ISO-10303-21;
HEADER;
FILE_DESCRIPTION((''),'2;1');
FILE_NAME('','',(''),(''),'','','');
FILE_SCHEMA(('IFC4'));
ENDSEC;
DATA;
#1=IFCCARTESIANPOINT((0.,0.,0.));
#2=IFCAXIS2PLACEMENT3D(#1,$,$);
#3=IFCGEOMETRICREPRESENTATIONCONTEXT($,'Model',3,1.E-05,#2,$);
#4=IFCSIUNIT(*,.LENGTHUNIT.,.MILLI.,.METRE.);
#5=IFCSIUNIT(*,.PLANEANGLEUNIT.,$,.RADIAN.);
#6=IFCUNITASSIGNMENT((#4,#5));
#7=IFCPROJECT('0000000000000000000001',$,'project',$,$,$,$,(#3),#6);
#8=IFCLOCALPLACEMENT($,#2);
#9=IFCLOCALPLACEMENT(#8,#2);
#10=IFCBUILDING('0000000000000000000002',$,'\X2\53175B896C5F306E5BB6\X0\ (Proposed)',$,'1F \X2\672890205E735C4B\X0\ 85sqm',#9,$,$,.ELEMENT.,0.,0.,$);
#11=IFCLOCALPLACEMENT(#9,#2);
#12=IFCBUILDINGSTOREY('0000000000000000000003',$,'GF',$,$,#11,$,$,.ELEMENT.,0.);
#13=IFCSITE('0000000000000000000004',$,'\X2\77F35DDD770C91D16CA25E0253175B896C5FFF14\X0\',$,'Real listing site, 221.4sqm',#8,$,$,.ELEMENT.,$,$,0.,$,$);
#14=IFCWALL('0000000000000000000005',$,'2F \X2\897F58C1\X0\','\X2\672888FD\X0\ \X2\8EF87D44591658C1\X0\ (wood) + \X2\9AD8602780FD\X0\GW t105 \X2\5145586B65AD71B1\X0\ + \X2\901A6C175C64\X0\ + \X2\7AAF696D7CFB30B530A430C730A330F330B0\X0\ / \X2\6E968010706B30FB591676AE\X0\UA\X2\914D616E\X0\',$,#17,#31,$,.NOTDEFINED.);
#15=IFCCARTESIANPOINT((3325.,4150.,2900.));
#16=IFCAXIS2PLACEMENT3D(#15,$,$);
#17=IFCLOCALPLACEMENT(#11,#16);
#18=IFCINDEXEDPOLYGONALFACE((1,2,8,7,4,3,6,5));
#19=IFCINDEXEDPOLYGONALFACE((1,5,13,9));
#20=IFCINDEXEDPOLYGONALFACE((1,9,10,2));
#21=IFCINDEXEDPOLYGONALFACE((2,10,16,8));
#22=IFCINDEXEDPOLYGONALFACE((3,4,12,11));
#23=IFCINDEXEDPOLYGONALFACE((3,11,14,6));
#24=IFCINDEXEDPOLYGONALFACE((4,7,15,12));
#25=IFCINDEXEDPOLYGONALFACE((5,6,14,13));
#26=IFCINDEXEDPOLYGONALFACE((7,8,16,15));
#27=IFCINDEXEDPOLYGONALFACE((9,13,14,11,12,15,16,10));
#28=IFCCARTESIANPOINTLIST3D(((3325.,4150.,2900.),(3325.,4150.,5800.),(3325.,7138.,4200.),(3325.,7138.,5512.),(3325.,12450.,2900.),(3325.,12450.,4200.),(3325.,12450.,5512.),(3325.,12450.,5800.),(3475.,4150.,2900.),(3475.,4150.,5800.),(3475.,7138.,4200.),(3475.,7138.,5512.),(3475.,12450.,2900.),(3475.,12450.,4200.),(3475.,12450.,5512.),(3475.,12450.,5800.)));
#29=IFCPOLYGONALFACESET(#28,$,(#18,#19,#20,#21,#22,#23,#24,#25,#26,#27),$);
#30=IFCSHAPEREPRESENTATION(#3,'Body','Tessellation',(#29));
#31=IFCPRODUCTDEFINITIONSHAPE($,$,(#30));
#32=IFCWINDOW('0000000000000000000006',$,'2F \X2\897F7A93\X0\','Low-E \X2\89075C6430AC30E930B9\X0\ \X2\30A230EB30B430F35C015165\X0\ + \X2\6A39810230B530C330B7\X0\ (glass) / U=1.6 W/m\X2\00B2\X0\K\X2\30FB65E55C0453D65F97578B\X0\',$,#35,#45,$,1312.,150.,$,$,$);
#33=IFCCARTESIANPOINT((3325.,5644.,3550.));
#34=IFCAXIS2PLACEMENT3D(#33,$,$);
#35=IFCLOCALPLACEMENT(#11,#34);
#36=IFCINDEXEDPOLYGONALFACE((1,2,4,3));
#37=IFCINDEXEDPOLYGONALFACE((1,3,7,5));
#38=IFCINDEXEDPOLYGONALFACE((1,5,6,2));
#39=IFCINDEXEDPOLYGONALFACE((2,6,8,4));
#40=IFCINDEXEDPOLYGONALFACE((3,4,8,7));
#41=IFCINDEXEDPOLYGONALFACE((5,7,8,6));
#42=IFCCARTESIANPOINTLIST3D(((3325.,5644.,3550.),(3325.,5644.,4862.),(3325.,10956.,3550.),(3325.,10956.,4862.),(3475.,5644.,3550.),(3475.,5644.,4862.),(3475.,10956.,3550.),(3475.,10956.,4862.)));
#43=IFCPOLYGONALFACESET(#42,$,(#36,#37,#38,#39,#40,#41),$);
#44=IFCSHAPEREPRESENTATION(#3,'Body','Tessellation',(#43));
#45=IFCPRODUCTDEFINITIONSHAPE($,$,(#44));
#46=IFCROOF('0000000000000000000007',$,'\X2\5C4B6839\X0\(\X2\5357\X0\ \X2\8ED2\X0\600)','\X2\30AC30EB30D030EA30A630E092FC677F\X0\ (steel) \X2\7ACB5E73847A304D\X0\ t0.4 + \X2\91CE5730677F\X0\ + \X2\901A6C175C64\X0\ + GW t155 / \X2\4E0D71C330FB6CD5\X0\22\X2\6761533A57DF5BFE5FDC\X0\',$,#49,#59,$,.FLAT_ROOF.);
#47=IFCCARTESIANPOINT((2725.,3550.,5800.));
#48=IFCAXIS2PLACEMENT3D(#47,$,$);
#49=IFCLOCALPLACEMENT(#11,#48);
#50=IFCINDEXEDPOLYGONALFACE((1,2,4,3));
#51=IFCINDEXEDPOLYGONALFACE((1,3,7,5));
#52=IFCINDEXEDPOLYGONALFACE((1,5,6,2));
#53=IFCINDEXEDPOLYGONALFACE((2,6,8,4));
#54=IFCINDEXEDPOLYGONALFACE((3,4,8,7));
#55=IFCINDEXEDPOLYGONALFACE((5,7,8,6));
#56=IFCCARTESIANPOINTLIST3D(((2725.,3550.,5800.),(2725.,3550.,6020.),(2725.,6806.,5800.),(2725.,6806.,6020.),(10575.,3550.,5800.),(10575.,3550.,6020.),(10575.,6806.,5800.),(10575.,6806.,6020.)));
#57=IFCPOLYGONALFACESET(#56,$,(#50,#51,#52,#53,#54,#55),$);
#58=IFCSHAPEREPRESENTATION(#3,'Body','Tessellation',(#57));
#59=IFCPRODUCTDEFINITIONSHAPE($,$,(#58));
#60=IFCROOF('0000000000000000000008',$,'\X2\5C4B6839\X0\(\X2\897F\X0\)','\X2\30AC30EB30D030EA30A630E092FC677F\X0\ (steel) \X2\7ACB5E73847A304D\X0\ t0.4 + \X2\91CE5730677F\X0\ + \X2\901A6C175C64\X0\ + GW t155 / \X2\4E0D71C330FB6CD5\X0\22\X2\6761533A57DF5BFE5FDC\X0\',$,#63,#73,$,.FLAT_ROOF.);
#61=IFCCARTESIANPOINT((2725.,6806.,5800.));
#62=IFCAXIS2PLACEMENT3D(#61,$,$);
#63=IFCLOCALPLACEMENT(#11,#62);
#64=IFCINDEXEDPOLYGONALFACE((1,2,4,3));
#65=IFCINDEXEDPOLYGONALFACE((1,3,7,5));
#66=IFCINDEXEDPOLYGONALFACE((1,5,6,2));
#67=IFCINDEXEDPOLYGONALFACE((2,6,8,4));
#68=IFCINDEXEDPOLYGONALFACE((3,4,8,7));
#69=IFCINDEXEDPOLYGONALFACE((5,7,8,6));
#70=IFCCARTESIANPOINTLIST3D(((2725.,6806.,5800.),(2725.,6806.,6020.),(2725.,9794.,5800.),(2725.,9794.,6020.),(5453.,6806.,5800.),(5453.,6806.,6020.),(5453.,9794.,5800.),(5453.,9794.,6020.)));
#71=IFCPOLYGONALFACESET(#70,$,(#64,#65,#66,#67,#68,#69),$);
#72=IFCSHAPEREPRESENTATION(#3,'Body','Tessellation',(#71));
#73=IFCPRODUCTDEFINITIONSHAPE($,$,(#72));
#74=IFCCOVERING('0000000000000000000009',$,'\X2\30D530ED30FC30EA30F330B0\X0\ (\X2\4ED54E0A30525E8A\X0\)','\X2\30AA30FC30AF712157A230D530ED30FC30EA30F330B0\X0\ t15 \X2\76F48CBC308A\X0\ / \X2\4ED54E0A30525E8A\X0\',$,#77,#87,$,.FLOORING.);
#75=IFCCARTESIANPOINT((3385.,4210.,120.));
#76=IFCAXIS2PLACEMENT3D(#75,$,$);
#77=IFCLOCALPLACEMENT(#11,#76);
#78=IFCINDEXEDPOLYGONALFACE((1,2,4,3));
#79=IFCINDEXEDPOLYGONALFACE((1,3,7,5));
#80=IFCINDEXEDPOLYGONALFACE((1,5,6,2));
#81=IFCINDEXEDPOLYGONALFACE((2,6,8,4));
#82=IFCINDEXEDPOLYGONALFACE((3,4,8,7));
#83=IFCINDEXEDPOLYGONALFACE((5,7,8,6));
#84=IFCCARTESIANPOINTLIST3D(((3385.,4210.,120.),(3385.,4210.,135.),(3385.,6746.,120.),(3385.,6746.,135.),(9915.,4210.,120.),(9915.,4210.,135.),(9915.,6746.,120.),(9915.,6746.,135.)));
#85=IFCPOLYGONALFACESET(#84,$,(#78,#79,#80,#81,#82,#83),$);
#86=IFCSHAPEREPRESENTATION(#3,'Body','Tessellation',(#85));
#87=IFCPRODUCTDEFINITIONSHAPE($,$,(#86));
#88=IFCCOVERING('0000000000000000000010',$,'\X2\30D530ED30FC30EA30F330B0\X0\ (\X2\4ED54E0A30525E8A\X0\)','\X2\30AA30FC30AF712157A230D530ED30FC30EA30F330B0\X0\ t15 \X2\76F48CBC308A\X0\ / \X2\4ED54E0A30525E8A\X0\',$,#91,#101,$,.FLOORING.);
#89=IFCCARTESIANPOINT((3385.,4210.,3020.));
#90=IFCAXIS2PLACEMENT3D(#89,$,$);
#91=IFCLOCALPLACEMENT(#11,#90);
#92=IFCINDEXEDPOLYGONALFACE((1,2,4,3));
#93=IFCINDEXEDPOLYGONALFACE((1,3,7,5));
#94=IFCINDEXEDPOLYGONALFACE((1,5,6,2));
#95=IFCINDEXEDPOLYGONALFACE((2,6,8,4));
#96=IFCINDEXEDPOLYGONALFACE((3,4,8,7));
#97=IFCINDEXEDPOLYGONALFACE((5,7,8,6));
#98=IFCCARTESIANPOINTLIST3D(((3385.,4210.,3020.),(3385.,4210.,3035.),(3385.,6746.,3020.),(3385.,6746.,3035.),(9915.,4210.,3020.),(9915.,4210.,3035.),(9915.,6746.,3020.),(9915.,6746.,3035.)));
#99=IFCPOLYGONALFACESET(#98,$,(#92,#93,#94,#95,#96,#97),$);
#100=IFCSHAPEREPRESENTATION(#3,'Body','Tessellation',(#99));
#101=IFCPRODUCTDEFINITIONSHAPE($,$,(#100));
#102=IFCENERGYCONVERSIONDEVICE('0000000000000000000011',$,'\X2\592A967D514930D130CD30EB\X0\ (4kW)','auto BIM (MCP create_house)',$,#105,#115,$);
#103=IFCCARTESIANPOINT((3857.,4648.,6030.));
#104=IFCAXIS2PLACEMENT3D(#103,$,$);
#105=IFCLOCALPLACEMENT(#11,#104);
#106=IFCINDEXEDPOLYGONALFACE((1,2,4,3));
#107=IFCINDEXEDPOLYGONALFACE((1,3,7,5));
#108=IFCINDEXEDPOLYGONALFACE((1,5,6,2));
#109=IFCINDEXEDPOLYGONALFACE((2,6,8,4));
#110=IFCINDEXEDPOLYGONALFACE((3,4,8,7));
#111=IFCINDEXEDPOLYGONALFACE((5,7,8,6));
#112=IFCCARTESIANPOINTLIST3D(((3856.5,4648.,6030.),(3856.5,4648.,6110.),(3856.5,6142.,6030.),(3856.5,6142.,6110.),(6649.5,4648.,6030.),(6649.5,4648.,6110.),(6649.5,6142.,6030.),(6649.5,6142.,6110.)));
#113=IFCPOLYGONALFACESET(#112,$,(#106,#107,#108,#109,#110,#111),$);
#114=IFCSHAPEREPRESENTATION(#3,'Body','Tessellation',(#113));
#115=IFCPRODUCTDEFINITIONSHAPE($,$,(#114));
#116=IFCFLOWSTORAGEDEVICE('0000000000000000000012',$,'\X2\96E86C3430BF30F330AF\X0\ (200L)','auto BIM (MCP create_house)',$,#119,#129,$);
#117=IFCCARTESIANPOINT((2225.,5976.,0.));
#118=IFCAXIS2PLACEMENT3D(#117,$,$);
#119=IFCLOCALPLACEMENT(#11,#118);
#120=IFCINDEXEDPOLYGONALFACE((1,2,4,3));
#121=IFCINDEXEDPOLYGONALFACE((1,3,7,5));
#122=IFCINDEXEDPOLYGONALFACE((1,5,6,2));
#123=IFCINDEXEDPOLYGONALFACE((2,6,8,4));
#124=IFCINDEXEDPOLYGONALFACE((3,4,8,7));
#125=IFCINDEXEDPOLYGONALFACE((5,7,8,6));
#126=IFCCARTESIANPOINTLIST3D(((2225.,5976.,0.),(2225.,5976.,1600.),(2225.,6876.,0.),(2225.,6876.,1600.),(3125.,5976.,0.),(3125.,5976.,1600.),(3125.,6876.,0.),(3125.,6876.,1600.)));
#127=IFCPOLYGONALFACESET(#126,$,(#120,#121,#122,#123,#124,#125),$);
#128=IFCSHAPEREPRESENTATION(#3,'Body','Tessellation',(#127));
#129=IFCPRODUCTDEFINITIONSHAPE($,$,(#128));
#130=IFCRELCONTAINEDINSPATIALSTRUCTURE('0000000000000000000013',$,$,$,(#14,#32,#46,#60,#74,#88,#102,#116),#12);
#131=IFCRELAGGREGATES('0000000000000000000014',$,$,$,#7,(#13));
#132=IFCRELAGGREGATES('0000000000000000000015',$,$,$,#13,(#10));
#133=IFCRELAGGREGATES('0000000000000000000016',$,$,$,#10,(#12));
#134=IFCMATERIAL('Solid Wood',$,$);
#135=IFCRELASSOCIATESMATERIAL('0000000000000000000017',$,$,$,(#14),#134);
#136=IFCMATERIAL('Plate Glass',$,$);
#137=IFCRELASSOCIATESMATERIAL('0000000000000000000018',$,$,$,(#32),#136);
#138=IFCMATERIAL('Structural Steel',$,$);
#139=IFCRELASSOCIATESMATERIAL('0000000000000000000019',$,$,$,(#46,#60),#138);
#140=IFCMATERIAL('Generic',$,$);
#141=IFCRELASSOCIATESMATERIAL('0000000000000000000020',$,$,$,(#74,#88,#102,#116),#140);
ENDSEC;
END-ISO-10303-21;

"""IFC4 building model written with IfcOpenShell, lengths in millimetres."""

from ifc_helpers import new_model, si_unit, frame, frame_2d, origin, place, context, project, spatial, rectangle, extrude, material, element, fill, save


model = new_model("IFC4")

# Units and contexts
model_context = context("Model", 3, precision=1e-05, world=origin())
ifc_project = project(units=[si_unit("LENGTHUNIT", "METRE", prefix="MILLI"), si_unit("PLANEANGLEUNIT", "RADIAN")], contexts=[model_context])

# Site, building, storey
site_placement = place(None, origin())
site = spatial("IfcSite", under=ifc_project, at=site_placement, Name="石川県金沢市北安江４", ObjectType="Real listing site, 221.4sqm", CompositionType="ELEMENT", RefElevation=0.0)
building_placement = place(site_placement, origin())
building = spatial("IfcBuilding", under=site, at=building_placement, Name="北安江の家 (Proposed)", ObjectType="1F 木造平屋 85sqm", CompositionType="ELEMENT", ElevationOfRefHeight=0.0, ElevationOfTerrain=0.0)
storey_placement = place(building_placement, origin())
storey = spatial("IfcBuildingStorey", under=building, at=storey_placement, Name="GF", CompositionType="ELEMENT", Elevation=0.0)

# Shared definitions
ifc_material_1 = material(Name="Solid Wood")
ifc_material_2 = material(Name="Generic")

# Shared definitions
ifc_material_3 = material(Name="Plate Glass")

# Wall, opening, window
wall_1_placement = place(storey_placement, frame((3325.0, 4150.0, 2900.0)))
wall_1 = element("IfcWall", 1, at=wall_1_placement, inside=storey, material=ifc_material_1, Name="2F 西壁", Description="木製 軸組外壁 (wood) + 高性能GW t105 充填断熱 + 通気層 + 窯業系サイディング / 準耐火・外皮UA配慮", PredefinedType="NOTDEFINED", context=model_context, shape_type="SweptSolid", body=[
    extrude(rectangle(XDim=150.0, YDim=8300.0, at=frame_2d((75.0, 4150.0))), frame((3325.0, 4150.0, 2900.0)), (0.0, 0.0, 1.0), 2900.0),
])
opening_1_placement = place(storey_placement, frame((3325.0, 5644.0, 3550.0)))
opening_1 = element("IfcOpeningElement", 2, at=opening_1_placement, cuts=wall_1, PredefinedType="NOTDEFINED", context=model_context, shape_type="SweptSolid", body=[
    extrude(rectangle(XDim=150.0, YDim=5312.0, at=frame_2d((75.0, 2656.0))), frame((3325.0, 5644.0, 3550.0)), (0.0, 0.0, 1.0), 1312.0),
])
window_1_placement = place(storey_placement, frame((3325.0, 5644.0, 3550.0)))
window_1 = element("IfcWindow", 3, at=window_1_placement, inside=storey, material=ifc_material_3, Name="2F 西窓", Description="Low-E 複層ガラス アルゴン封入 + 樹脂サッシ (glass) / U=1.6 W/m²K・日射取得型", OverallHeight=1312.0, OverallWidth=150.0, context=model_context, shape_type="SweptSolid", body=[
    extrude(rectangle(XDim=150.0, YDim=5312.0, at=frame_2d((75.0, 2656.0))), frame((3325.0, 5644.0, 3550.0)), (0.0, 0.0, 1.0), 1312.0),
])
fill(opening_1, window_1)

# Roofs
ifc_material_4 = material(Name="Structural Steel")
roof_1_placement = place(storey_placement, frame((2725.0, 3550.0, 5800.0)))
element("IfcRoof", 4, at=roof_1_placement, inside=storey, material=ifc_material_4, Name="屋根(南 軒600)", Description="ガルバリウム鋼板 (steel) 立平葺き t0.4 + 野地板 + 通気層 + GW t155 / 不燃・法22条区域対応", PredefinedType="FLAT_ROOF", context=model_context, shape_type="SweptSolid", body=[
    extrude(rectangle(XDim=7850.0, YDim=3256.0, at=frame_2d((3925.0, 1628.0))), frame((2725.0, 3550.0, 5800.0)), (0.0, 0.0, 1.0), 220.0),
])
roof_2_placement = place(storey_placement, frame((2725.0, 6806.0, 5800.0)))
element("IfcRoof", 5, at=roof_2_placement, inside=storey, material=ifc_material_4, Name="屋根(西)", Description="ガルバリウム鋼板 (steel) 立平葺き t0.4 + 野地板 + 通気層 + GW t155 / 不燃・法22条区域対応", PredefinedType="FLAT_ROOF", context=model_context, shape_type="SweptSolid", body=[
    extrude(rectangle(XDim=2728.0, YDim=2988.0, at=frame_2d((1364.0, 1494.0))), frame((2725.0, 6806.0, 5800.0)), (0.0, 0.0, 1.0), 220.0),
])

# Coverings
covering_1_placement = place(storey_placement, frame((3385.0, 4210.0, 120.0)))
element("IfcCovering", 6, at=covering_1_placement, inside=storey, material=ifc_material_2, Name="フローリング (仕上げ床)", Description="オーク無垢フローリング t15 直貼り / 仕上げ床", PredefinedType="FLOORING", context=model_context, shape_type="SweptSolid", body=[
    extrude(rectangle(XDim=6530.0, YDim=2536.0, at=frame_2d((3265.0, 1268.0))), frame((3385.0, 4210.0, 120.0)), (0.0, 0.0, 1.0), 15.0),
])
covering_2_placement = place(storey_placement, frame((3385.0, 4210.0, 3020.0)))
element("IfcCovering", 7, at=covering_2_placement, inside=storey, material=ifc_material_2, Name="フローリング (仕上げ床)", Description="オーク無垢フローリング t15 直貼り / 仕上げ床", PredefinedType="FLOORING", context=model_context, shape_type="SweptSolid", body=[
    extrude(rectangle(XDim=6530.0, YDim=2536.0, at=frame_2d((3265.0, 1268.0))), frame((3385.0, 4210.0, 3020.0)), (0.0, 0.0, 1.0), 15.0),
])

# Energy conversion device
energy_conversion_device_placement = place(storey_placement, frame((3857.0, 4648.0, 6030.0)))
element("IfcEnergyConversionDevice", 8, at=energy_conversion_device_placement, inside=storey, material=ifc_material_2, Name="太陽光パネル (4kW)", Description="auto BIM (MCP create_house)", context=model_context, shape_type="SweptSolid", body=[
    extrude(rectangle(XDim=2793.0, YDim=1494.0, at=frame_2d((1396.0, 747.0))), frame((3857.0, 4648.0, 6030.0)), (0.0, 0.0, 1.0), 80.0),
])

# Flow storage device
flow_storage_device_placement = place(storey_placement, frame((2225.0, 5976.0, 0.0)))
element("IfcFlowStorageDevice", 9, at=flow_storage_device_placement, inside=storey, material=ifc_material_2, Name="雨水タンク (200L)", Description="auto BIM (MCP create_house)", context=model_context, shape_type="SweptSolid", body=[
    extrude(rectangle(XDim=900.0, YDim=900.0, at=frame_2d((450.0, 450.0))), frame((2225.0, 5976.0, 0.0)), (0.0, 0.0, 1.0), 1600.0),
])

save(model, "model.ifc")
